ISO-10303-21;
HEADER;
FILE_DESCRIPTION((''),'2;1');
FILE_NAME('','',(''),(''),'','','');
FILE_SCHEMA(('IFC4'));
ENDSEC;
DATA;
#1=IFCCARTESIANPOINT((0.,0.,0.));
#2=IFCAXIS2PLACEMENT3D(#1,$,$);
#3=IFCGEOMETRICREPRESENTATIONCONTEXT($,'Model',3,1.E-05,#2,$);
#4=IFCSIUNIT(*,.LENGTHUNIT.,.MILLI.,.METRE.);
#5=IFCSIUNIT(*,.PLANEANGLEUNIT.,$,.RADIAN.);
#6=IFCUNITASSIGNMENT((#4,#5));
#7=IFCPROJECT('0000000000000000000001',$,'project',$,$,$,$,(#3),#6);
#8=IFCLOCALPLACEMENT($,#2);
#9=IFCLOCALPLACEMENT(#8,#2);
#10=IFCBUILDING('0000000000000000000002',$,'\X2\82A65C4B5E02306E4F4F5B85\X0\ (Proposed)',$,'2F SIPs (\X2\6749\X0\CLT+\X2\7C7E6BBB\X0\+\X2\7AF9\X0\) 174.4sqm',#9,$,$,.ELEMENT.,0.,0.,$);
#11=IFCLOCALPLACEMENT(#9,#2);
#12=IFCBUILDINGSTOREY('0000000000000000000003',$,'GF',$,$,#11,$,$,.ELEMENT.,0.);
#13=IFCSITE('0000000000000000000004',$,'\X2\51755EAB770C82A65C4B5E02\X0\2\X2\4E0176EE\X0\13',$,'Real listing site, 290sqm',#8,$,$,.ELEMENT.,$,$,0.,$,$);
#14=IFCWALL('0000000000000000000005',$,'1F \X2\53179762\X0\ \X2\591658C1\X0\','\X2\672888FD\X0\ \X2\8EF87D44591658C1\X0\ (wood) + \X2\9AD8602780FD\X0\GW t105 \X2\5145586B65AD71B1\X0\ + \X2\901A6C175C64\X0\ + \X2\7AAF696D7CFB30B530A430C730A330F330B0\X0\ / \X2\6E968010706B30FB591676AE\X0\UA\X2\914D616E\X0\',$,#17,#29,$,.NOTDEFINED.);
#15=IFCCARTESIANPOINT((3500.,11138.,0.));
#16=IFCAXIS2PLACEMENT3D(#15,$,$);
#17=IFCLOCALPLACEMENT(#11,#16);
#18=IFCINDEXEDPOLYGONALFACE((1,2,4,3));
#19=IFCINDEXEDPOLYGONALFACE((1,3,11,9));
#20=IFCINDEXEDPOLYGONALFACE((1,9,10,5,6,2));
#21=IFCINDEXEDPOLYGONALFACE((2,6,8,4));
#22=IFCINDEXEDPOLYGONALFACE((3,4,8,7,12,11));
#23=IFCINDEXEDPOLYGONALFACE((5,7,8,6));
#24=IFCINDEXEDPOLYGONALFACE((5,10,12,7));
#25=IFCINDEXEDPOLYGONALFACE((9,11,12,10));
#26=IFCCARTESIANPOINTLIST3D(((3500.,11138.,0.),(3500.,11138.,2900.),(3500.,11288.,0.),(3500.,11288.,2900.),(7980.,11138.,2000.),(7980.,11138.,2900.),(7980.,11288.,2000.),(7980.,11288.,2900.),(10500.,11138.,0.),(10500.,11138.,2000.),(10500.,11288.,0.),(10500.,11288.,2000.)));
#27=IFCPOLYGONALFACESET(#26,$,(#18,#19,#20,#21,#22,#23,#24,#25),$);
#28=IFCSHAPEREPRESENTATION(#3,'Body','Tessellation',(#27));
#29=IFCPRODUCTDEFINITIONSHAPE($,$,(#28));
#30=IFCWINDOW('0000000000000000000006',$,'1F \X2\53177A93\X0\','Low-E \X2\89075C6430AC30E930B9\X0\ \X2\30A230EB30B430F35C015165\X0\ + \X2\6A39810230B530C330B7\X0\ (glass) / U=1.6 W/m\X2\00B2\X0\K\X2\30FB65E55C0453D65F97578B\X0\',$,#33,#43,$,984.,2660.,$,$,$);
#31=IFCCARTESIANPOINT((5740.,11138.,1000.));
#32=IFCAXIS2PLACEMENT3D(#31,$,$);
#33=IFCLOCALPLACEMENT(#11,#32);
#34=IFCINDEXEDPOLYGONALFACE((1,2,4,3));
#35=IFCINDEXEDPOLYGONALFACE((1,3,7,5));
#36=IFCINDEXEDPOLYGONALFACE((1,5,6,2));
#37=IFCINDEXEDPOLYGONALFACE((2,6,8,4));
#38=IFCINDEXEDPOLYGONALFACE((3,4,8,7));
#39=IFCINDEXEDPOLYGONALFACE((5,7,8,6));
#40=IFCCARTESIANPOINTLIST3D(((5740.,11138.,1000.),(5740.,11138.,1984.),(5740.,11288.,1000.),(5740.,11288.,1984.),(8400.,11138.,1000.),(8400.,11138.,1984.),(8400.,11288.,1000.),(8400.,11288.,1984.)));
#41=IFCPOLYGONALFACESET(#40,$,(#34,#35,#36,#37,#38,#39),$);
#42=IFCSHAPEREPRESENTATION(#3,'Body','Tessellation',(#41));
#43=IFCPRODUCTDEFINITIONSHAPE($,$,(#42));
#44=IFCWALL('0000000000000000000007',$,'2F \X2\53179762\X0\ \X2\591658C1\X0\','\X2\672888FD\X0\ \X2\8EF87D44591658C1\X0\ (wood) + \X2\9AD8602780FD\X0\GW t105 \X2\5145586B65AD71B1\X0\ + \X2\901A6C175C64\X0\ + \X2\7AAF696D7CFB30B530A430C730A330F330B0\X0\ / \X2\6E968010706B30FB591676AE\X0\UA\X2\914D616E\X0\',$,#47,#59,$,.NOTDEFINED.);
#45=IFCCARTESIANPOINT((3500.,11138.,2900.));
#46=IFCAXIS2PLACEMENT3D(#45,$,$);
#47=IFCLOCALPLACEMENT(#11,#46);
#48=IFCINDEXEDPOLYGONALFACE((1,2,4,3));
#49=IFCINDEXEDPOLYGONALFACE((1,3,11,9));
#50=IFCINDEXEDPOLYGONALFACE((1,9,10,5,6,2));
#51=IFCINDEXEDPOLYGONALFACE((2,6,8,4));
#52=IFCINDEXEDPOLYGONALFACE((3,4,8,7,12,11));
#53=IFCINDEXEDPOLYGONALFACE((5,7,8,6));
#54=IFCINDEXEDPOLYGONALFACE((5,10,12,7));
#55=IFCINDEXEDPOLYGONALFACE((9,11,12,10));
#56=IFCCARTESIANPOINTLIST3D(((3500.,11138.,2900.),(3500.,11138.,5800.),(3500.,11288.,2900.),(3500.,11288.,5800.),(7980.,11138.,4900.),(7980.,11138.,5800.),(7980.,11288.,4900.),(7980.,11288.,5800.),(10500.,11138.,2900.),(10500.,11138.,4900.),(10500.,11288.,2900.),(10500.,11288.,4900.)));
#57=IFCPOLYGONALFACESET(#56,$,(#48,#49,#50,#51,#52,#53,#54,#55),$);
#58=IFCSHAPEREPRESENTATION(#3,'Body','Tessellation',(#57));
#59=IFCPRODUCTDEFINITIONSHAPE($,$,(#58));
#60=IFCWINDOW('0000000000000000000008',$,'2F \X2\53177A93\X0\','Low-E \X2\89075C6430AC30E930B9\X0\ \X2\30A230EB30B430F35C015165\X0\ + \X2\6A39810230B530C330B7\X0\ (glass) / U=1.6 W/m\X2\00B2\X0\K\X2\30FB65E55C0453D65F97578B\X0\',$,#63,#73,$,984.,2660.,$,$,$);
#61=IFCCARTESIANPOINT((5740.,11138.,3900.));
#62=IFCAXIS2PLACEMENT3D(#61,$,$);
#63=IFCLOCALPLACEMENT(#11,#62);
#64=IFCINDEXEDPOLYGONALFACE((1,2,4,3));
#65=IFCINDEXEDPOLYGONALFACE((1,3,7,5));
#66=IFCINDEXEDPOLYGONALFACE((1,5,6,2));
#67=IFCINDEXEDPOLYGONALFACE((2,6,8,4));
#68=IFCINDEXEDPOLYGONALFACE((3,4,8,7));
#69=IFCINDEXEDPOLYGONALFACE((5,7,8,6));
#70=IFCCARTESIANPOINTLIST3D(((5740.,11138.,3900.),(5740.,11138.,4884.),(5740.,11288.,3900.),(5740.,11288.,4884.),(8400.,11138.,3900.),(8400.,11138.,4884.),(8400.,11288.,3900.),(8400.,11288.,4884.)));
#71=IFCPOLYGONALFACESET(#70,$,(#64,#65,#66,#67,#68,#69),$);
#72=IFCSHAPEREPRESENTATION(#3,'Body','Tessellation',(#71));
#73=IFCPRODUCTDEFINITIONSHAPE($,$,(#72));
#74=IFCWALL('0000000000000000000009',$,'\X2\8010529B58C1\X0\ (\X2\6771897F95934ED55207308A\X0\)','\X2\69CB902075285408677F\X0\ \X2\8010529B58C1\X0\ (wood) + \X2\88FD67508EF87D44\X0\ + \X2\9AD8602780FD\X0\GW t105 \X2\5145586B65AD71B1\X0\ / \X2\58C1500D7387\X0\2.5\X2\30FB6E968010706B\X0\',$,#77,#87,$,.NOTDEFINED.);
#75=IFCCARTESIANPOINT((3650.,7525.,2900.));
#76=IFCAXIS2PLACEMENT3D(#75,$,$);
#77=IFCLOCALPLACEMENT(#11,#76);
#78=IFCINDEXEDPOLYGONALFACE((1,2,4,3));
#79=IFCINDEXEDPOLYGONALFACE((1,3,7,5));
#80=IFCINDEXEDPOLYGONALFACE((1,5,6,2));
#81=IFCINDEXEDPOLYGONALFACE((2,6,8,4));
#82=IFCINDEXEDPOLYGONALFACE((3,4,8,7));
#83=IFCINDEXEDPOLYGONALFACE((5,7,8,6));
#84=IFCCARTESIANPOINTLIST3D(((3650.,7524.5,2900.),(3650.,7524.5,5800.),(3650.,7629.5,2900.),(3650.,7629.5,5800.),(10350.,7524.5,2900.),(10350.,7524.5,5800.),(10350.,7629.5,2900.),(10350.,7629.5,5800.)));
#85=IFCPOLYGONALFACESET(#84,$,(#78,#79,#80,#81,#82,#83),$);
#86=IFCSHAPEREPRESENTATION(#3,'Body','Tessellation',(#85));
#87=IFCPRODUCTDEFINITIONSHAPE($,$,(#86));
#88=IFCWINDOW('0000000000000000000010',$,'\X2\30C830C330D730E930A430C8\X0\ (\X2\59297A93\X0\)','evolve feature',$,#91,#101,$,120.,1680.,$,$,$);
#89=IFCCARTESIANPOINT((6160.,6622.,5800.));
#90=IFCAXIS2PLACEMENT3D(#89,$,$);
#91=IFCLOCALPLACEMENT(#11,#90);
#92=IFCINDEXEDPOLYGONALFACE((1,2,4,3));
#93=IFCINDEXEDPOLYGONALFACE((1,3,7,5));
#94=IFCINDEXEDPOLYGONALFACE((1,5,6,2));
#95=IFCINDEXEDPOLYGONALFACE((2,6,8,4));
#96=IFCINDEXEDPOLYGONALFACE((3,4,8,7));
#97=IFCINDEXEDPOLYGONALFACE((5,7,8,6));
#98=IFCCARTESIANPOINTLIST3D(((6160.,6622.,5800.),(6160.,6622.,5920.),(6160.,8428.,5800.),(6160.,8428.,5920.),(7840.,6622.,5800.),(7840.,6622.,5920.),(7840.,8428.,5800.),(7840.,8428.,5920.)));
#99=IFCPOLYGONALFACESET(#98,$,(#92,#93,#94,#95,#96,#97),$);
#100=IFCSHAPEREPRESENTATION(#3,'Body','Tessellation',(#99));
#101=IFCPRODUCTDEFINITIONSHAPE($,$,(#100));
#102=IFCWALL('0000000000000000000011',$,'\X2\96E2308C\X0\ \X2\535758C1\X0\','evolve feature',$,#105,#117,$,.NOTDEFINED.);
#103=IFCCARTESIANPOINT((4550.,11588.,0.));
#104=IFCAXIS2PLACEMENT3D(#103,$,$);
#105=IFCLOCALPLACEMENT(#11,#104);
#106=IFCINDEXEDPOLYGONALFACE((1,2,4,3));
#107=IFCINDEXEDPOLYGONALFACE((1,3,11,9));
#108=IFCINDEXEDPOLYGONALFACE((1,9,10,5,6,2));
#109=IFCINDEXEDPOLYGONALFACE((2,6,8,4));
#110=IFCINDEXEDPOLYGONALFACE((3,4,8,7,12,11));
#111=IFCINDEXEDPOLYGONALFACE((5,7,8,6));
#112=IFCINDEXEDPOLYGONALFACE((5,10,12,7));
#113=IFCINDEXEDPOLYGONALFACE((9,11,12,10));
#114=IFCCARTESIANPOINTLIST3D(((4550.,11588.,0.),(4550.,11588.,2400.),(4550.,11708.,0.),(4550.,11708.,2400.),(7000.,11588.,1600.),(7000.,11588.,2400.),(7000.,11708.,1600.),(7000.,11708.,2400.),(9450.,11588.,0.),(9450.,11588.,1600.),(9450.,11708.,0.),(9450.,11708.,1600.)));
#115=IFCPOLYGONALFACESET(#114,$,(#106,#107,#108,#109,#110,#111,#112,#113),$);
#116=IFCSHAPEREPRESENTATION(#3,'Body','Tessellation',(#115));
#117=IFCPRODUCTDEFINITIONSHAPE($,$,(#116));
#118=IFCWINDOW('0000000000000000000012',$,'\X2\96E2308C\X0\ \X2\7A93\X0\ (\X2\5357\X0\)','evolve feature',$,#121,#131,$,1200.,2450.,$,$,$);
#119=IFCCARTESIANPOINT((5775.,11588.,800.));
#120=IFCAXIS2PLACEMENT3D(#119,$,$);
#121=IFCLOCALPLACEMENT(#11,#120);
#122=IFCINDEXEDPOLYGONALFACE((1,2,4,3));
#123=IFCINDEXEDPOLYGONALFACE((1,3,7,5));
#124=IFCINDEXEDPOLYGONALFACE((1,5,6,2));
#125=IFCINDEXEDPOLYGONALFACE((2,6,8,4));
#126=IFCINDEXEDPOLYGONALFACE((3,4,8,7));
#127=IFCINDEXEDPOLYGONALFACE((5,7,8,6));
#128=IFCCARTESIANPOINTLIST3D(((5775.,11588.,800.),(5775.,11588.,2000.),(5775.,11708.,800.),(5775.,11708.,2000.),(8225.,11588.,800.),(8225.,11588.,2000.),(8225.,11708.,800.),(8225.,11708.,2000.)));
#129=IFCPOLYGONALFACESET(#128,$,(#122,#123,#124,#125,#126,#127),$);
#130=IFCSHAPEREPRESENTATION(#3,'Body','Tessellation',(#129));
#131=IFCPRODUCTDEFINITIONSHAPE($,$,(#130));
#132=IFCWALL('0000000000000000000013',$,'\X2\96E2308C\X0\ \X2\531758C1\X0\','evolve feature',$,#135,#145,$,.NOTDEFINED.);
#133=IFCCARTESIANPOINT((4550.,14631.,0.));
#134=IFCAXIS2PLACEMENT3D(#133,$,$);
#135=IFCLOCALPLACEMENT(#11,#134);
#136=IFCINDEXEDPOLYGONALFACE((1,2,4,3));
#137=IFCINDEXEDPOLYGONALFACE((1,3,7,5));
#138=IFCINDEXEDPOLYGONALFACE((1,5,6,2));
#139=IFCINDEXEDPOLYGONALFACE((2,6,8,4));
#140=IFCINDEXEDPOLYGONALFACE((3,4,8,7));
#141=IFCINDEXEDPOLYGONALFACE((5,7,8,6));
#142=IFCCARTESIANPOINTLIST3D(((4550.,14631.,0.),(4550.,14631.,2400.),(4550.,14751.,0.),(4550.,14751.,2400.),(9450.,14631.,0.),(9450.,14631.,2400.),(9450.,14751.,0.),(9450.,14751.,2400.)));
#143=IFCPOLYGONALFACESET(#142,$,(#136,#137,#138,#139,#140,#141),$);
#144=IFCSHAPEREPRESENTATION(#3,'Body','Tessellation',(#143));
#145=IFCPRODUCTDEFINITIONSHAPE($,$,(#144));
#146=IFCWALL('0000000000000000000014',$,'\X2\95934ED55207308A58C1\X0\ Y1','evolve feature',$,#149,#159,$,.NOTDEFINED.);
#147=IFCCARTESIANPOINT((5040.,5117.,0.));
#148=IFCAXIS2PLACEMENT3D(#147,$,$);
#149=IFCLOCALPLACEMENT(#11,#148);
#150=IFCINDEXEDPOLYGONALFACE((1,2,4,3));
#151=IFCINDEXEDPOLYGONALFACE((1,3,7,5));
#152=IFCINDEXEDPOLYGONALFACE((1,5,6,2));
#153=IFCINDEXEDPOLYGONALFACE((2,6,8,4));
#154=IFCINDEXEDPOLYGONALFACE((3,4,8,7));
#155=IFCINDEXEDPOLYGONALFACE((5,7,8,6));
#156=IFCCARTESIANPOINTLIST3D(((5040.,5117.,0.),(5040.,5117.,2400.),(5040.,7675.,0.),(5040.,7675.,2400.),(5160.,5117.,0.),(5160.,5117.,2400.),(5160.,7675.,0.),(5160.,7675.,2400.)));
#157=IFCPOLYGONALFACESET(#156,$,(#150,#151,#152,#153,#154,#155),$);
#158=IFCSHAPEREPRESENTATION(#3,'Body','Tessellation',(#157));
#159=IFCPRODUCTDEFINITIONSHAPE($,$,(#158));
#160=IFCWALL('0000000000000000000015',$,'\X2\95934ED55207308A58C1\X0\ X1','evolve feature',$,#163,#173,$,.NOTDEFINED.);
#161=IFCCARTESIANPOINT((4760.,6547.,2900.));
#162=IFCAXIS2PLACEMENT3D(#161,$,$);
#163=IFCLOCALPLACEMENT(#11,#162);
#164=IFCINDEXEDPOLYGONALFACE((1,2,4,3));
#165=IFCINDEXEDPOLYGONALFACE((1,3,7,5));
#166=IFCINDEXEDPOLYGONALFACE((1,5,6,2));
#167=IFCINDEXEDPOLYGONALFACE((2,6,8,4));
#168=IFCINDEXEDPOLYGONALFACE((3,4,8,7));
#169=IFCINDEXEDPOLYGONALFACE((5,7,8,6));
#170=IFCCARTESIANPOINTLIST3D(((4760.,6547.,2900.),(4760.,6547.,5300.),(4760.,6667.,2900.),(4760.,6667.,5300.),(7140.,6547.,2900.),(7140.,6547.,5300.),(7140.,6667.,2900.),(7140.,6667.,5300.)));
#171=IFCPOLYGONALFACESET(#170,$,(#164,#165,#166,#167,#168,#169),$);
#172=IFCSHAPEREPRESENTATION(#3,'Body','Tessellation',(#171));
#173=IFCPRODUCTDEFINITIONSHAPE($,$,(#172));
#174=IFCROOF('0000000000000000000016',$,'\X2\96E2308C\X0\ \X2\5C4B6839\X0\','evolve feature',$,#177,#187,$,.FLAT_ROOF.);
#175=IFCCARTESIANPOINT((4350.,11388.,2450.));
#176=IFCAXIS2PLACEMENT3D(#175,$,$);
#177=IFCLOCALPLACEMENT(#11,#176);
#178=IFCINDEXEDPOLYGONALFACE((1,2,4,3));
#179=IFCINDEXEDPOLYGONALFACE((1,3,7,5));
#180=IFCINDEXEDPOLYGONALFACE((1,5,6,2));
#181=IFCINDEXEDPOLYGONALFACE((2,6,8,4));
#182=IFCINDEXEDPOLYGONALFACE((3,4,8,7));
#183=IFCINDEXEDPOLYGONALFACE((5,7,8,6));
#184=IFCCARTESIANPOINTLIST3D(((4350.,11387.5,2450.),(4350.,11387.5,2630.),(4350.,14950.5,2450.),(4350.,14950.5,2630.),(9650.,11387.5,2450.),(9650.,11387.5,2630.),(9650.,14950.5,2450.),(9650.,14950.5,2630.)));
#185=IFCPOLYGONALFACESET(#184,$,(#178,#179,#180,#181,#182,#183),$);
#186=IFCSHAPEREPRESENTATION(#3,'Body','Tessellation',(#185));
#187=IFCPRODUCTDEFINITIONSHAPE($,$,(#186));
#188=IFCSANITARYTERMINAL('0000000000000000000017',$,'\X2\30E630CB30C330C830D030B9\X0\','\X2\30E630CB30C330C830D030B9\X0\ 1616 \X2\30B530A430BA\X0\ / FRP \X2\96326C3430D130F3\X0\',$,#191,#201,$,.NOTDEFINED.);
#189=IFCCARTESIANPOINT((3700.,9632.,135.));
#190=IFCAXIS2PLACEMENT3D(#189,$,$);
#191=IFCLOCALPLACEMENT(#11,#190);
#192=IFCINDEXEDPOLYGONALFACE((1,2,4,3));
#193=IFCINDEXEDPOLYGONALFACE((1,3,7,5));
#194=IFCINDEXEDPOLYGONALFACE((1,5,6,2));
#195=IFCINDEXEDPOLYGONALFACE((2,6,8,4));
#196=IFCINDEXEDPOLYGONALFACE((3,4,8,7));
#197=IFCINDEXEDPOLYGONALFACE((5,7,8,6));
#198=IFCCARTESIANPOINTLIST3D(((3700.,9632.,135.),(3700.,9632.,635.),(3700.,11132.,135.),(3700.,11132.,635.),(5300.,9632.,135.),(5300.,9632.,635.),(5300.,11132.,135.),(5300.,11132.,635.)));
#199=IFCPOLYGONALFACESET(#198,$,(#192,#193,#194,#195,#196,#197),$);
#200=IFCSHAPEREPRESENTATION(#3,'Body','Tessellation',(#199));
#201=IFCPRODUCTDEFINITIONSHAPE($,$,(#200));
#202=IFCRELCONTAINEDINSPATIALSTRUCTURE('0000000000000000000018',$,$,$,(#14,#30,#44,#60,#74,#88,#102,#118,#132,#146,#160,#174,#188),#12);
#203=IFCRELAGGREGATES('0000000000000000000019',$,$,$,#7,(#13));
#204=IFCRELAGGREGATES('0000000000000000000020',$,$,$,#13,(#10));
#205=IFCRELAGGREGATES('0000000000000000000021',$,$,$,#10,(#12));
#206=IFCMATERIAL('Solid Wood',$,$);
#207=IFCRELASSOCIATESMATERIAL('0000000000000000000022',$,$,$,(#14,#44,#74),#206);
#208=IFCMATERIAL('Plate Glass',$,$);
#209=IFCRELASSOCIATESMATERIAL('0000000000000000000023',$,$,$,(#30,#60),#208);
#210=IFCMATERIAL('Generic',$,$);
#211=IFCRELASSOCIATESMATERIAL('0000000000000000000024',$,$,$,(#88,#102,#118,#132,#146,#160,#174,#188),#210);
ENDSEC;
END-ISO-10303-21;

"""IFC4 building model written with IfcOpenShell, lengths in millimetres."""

from ifc_helpers import new_model, si_unit, frame, frame_2d, origin, place, context, project, spatial, rectangle, extrude, material, element, fill, save


model = new_model("IFC4")

# Units and contexts
model_context = context("Model", 3, precision=1e-05, world=origin())
ifc_project = project(units=[si_unit("LENGTHUNIT", "METRE", prefix="MILLI"), si_unit("PLANEANGLEUNIT", "RADIAN")], contexts=[model_context])

# Site, building, storey
site_placement = place(None, origin())
site = spatial("IfcSite", under=ifc_project, at=site_placement, Name="兵庫県芦屋市2丁目13", ObjectType="Real listing site, 290sqm", CompositionType="ELEMENT", RefElevation=0.0)
building_placement = place(site_placement, origin())
building = spatial("IfcBuilding", under=site, at=building_placement, Name="芦屋市の住宅 (Proposed)", ObjectType="2F SIPs (杉CLT+籾殻+竹) 174.4sqm", CompositionType="ELEMENT", ElevationOfRefHeight=0.0, ElevationOfTerrain=0.0)
storey_placement = place(building_placement, origin())
storey = spatial("IfcBuildingStorey", under=building, at=storey_placement, Name="GF", CompositionType="ELEMENT", Elevation=0.0)

# Shared definitions
ifc_material_1 = material(Name="Generic")

# Wall, opening, window
ifc_material_2 = material(Name="Solid Wood")
wall_1_placement = place(storey_placement, frame((3500.0, 11138.0, 0.0)))
wall_1 = element("IfcWall", 1, at=wall_1_placement, inside=storey, material=ifc_material_2, Name="1F 北面 外壁", Description="木製 軸組外壁 (wood) + 高性能GW t105 充填断熱 + 通気層 + 窯業系サイディング / 準耐火・外皮UA配慮", PredefinedType="NOTDEFINED", context=model_context, shape_type="SweptSolid", body=[
    extrude(rectangle(XDim=7000.0, YDim=150.0, at=frame_2d((3500.0, 75.0))), frame((3500.0, 11138.0, 0.0)), (0.0, 0.0, 1.0), 2900.0),
])
opening_1_placement = place(storey_placement, frame((5740.0, 11138.0, 1000.0)))
opening_1 = element("IfcOpeningElement", 2, at=opening_1_placement, cuts=wall_1, PredefinedType="NOTDEFINED", context=model_context, shape_type="SweptSolid", body=[
    extrude(rectangle(XDim=2660.0, YDim=150.0, at=frame_2d((1330.0, 75.0))), frame((5740.0, 11138.0, 1000.0)), (0.0, 0.0, 1.0), 984.0),
])
ifc_material_3 = material(Name="Plate Glass")
window_1_placement = place(storey_placement, frame((5740.0, 11138.0, 1000.0)))
window_1 = element("IfcWindow", 3, at=window_1_placement, inside=storey, material=ifc_material_3, Name="1F 北窓", Description="Low-E 複層ガラス アルゴン封入 + 樹脂サッシ (glass) / U=1.6 W/m²K・日射取得型", OverallHeight=984.0, OverallWidth=2660.0, context=model_context, shape_type="SweptSolid", body=[
    extrude(rectangle(XDim=2660.0, YDim=150.0, at=frame_2d((1330.0, 75.0))), frame((5740.0, 11138.0, 1000.0)), (0.0, 0.0, 1.0), 984.0),
])
fill(opening_1, window_1)

# Wall, opening, window
wall_2_placement = place(storey_placement, frame((3500.0, 11138.0, 2900.0)))
wall_2 = element("IfcWall", 4, at=wall_2_placement, inside=storey, material=ifc_material_2, Name="2F 北面 外壁", Description="木製 軸組外壁 (wood) + 高性能GW t105 充填断熱 + 通気層 + 窯業系サイディング / 準耐火・外皮UA配慮", PredefinedType="NOTDEFINED", context=model_context, shape_type="SweptSolid", body=[
    extrude(rectangle(XDim=7000.0, YDim=150.0, at=frame_2d((3500.0, 75.0))), frame((3500.0, 11138.0, 2900.0)), (0.0, 0.0, 1.0), 2900.0),
])
opening_2_placement = place(storey_placement, frame((5740.0, 11138.0, 3900.0)))
opening_2 = element("IfcOpeningElement", 5, at=opening_2_placement, cuts=wall_2, PredefinedType="NOTDEFINED", context=model_context, shape_type="SweptSolid", body=[
    extrude(rectangle(XDim=2660.0, YDim=150.0, at=frame_2d((1330.0, 75.0))), frame((5740.0, 11138.0, 3900.0)), (0.0, 0.0, 1.0), 984.0),
])
window_2_placement = place(storey_placement, frame((5740.0, 11138.0, 3900.0)))
window_2 = element("IfcWindow", 6, at=window_2_placement, inside=storey, material=ifc_material_3, Name="2F 北窓", Description="Low-E 複層ガラス アルゴン封入 + 樹脂サッシ (glass) / U=1.6 W/m²K・日射取得型", OverallHeight=984.0, OverallWidth=2660.0, context=model_context, shape_type="SweptSolid", body=[
    extrude(rectangle(XDim=2660.0, YDim=150.0, at=frame_2d((1330.0, 75.0))), frame((5740.0, 11138.0, 3900.0)), (0.0, 0.0, 1.0), 984.0),
])
fill(opening_2, window_2)

# Wall
wall_3_placement = place(storey_placement, frame((3650.0, 7525.0, 2900.0)))
element("IfcWall", 7, at=wall_3_placement, inside=storey, material=ifc_material_2, Name="耐力壁 (東西間仕切り)", Description="構造用合板 耐力壁 (wood) + 製材軸組 + 高性能GW t105 充填断熱 / 壁倍率2.5・準耐火", PredefinedType="NOTDEFINED", context=model_context, shape_type="SweptSolid", body=[
    extrude(rectangle(XDim=6700.0, YDim=105.0, at=frame_2d((3350.0, 52.0))), frame((3650.0, 7525.0, 2900.0)), (0.0, 0.0, 1.0), 2900.0),
])

# Window
window_3_placement = place(storey_placement, frame((6160.0, 6622.0, 5800.0)))
element("IfcWindow", 8, at=window_3_placement, inside=storey, material=ifc_material_1, Name="トップライト (天窓)", Description="evolve feature", OverallHeight=120.0, OverallWidth=1680.0, context=model_context, shape_type="SweptSolid", body=[
    extrude(rectangle(XDim=1680.0, YDim=1806.0, at=frame_2d((840.0, 903.0))), frame((6160.0, 6622.0, 5800.0)), (0.0, 0.0, 1.0), 120.0),
])

# Wall, opening, window
wall_4_placement = place(storey_placement, frame((4550.0, 11588.0, 0.0)))
wall_4 = element("IfcWall", 9, at=wall_4_placement, inside=storey, material=ifc_material_1, Name="離れ 南壁", Description="evolve feature", PredefinedType="NOTDEFINED", context=model_context, shape_type="SweptSolid", body=[
    extrude(rectangle(XDim=4900.0, YDim=120.0, at=frame_2d((2450.0, 60.0))), frame((4550.0, 11588.0, 0.0)), (0.0, 0.0, 1.0), 2400.0),
])
opening_3_placement = place(storey_placement, frame((5775.0, 11588.0, 800.0)))
opening_3 = element("IfcOpeningElement", 10, at=opening_3_placement, cuts=wall_4, PredefinedType="NOTDEFINED", context=model_context, shape_type="SweptSolid", body=[
    extrude(rectangle(XDim=2450.0, YDim=120.0, at=frame_2d((1225.0, 60.0))), frame((5775.0, 11588.0, 800.0)), (0.0, 0.0, 1.0), 1200.0),
])
window_4_placement = place(storey_placement, frame((5775.0, 11588.0, 800.0)))
window_4 = element("IfcWindow", 11, at=window_4_placement, inside=storey, material=ifc_material_1, Name="離れ 窓 (南)", Description="evolve feature", OverallHeight=1200.0, OverallWidth=2450.0, context=model_context, shape_type="SweptSolid", body=[
    extrude(rectangle(XDim=2450.0, YDim=120.0, at=frame_2d((1225.0, 60.0))), frame((5775.0, 11588.0, 800.0)), (0.0, 0.0, 1.0), 1200.0),
])
fill(opening_3, window_4)

# Walls
wall_5_placement = place(storey_placement, frame((4550.0, 14631.0, 0.0)))
element("IfcWall", 12, at=wall_5_placement, inside=storey, material=ifc_material_1, Name="離れ 北壁", Description="evolve feature", PredefinedType="NOTDEFINED", context=model_context, shape_type="SweptSolid", body=[
    extrude(rectangle(XDim=4900.0, YDim=120.0, at=frame_2d((2450.0, 60.0))), frame((4550.0, 14631.0, 0.0)), (0.0, 0.0, 1.0), 2400.0),
])
wall_6_placement = place(storey_placement, frame((5040.0, 5117.0, 0.0)))
element("IfcWall", 13, at=wall_6_placement, inside=storey, material=ifc_material_1, Name="間仕切り壁 Y1", Description="evolve feature", PredefinedType="NOTDEFINED", context=model_context, shape_type="SweptSolid", body=[
    extrude(rectangle(XDim=120.0, YDim=2558.0, at=frame_2d((60.0, 1279.0))), frame((5040.0, 5117.0, 0.0)), (0.0, 0.0, 1.0), 2400.0),
])
wall_7_placement = place(storey_placement, frame((4760.0, 6547.0, 2900.0)))
element("IfcWall", 14, at=wall_7_placement, inside=storey, material=ifc_material_1, Name="間仕切り壁 X1", Description="evolve feature", PredefinedType="NOTDEFINED", context=model_context, shape_type="SweptSolid", body=[
    extrude(rectangle(XDim=2380.0, YDim=120.0, at=frame_2d((1190.0, 60.0))), frame((4760.0, 6547.0, 2900.0)), (0.0, 0.0, 1.0), 2400.0),
])

# Roof
roof_placement = place(storey_placement, frame((4350.0, 11388.0, 2450.0)))
element("IfcRoof", 15, at=roof_placement, inside=storey, material=ifc_material_1, Name="離れ 屋根", Description="evolve feature", PredefinedType="FLAT_ROOF", context=model_context, shape_type="SweptSolid", body=[
    extrude(rectangle(XDim=5300.0, YDim=3563.0, at=frame_2d((2650.0, 1781.0))), frame((4350.0, 11388.0, 2450.0)), (0.0, 0.0, 1.0), 180.0),
])

# Sanitary terminal
sanitary_terminal_1_placement = place(storey_placement, frame((3700.0, 9632.0, 135.0)))
element("IfcSanitaryTerminal", 16, at=sanitary_terminal_1_placement, inside=storey, material=ifc_material_1, Name="ユニットバス", Description="ユニットバス 1616 サイズ / FRP 防水パン", PredefinedType="NOTDEFINED", context=model_context, shape_type="SweptSolid", body=[
    extrude(rectangle(XDim=1600.0, YDim=1500.0, at=frame_2d((800.0, 750.0))), frame((3700.0, 9632.0, 135.0)), (0.0, 0.0, 1.0), 500.0),
])

save(model, "model.ifc")
